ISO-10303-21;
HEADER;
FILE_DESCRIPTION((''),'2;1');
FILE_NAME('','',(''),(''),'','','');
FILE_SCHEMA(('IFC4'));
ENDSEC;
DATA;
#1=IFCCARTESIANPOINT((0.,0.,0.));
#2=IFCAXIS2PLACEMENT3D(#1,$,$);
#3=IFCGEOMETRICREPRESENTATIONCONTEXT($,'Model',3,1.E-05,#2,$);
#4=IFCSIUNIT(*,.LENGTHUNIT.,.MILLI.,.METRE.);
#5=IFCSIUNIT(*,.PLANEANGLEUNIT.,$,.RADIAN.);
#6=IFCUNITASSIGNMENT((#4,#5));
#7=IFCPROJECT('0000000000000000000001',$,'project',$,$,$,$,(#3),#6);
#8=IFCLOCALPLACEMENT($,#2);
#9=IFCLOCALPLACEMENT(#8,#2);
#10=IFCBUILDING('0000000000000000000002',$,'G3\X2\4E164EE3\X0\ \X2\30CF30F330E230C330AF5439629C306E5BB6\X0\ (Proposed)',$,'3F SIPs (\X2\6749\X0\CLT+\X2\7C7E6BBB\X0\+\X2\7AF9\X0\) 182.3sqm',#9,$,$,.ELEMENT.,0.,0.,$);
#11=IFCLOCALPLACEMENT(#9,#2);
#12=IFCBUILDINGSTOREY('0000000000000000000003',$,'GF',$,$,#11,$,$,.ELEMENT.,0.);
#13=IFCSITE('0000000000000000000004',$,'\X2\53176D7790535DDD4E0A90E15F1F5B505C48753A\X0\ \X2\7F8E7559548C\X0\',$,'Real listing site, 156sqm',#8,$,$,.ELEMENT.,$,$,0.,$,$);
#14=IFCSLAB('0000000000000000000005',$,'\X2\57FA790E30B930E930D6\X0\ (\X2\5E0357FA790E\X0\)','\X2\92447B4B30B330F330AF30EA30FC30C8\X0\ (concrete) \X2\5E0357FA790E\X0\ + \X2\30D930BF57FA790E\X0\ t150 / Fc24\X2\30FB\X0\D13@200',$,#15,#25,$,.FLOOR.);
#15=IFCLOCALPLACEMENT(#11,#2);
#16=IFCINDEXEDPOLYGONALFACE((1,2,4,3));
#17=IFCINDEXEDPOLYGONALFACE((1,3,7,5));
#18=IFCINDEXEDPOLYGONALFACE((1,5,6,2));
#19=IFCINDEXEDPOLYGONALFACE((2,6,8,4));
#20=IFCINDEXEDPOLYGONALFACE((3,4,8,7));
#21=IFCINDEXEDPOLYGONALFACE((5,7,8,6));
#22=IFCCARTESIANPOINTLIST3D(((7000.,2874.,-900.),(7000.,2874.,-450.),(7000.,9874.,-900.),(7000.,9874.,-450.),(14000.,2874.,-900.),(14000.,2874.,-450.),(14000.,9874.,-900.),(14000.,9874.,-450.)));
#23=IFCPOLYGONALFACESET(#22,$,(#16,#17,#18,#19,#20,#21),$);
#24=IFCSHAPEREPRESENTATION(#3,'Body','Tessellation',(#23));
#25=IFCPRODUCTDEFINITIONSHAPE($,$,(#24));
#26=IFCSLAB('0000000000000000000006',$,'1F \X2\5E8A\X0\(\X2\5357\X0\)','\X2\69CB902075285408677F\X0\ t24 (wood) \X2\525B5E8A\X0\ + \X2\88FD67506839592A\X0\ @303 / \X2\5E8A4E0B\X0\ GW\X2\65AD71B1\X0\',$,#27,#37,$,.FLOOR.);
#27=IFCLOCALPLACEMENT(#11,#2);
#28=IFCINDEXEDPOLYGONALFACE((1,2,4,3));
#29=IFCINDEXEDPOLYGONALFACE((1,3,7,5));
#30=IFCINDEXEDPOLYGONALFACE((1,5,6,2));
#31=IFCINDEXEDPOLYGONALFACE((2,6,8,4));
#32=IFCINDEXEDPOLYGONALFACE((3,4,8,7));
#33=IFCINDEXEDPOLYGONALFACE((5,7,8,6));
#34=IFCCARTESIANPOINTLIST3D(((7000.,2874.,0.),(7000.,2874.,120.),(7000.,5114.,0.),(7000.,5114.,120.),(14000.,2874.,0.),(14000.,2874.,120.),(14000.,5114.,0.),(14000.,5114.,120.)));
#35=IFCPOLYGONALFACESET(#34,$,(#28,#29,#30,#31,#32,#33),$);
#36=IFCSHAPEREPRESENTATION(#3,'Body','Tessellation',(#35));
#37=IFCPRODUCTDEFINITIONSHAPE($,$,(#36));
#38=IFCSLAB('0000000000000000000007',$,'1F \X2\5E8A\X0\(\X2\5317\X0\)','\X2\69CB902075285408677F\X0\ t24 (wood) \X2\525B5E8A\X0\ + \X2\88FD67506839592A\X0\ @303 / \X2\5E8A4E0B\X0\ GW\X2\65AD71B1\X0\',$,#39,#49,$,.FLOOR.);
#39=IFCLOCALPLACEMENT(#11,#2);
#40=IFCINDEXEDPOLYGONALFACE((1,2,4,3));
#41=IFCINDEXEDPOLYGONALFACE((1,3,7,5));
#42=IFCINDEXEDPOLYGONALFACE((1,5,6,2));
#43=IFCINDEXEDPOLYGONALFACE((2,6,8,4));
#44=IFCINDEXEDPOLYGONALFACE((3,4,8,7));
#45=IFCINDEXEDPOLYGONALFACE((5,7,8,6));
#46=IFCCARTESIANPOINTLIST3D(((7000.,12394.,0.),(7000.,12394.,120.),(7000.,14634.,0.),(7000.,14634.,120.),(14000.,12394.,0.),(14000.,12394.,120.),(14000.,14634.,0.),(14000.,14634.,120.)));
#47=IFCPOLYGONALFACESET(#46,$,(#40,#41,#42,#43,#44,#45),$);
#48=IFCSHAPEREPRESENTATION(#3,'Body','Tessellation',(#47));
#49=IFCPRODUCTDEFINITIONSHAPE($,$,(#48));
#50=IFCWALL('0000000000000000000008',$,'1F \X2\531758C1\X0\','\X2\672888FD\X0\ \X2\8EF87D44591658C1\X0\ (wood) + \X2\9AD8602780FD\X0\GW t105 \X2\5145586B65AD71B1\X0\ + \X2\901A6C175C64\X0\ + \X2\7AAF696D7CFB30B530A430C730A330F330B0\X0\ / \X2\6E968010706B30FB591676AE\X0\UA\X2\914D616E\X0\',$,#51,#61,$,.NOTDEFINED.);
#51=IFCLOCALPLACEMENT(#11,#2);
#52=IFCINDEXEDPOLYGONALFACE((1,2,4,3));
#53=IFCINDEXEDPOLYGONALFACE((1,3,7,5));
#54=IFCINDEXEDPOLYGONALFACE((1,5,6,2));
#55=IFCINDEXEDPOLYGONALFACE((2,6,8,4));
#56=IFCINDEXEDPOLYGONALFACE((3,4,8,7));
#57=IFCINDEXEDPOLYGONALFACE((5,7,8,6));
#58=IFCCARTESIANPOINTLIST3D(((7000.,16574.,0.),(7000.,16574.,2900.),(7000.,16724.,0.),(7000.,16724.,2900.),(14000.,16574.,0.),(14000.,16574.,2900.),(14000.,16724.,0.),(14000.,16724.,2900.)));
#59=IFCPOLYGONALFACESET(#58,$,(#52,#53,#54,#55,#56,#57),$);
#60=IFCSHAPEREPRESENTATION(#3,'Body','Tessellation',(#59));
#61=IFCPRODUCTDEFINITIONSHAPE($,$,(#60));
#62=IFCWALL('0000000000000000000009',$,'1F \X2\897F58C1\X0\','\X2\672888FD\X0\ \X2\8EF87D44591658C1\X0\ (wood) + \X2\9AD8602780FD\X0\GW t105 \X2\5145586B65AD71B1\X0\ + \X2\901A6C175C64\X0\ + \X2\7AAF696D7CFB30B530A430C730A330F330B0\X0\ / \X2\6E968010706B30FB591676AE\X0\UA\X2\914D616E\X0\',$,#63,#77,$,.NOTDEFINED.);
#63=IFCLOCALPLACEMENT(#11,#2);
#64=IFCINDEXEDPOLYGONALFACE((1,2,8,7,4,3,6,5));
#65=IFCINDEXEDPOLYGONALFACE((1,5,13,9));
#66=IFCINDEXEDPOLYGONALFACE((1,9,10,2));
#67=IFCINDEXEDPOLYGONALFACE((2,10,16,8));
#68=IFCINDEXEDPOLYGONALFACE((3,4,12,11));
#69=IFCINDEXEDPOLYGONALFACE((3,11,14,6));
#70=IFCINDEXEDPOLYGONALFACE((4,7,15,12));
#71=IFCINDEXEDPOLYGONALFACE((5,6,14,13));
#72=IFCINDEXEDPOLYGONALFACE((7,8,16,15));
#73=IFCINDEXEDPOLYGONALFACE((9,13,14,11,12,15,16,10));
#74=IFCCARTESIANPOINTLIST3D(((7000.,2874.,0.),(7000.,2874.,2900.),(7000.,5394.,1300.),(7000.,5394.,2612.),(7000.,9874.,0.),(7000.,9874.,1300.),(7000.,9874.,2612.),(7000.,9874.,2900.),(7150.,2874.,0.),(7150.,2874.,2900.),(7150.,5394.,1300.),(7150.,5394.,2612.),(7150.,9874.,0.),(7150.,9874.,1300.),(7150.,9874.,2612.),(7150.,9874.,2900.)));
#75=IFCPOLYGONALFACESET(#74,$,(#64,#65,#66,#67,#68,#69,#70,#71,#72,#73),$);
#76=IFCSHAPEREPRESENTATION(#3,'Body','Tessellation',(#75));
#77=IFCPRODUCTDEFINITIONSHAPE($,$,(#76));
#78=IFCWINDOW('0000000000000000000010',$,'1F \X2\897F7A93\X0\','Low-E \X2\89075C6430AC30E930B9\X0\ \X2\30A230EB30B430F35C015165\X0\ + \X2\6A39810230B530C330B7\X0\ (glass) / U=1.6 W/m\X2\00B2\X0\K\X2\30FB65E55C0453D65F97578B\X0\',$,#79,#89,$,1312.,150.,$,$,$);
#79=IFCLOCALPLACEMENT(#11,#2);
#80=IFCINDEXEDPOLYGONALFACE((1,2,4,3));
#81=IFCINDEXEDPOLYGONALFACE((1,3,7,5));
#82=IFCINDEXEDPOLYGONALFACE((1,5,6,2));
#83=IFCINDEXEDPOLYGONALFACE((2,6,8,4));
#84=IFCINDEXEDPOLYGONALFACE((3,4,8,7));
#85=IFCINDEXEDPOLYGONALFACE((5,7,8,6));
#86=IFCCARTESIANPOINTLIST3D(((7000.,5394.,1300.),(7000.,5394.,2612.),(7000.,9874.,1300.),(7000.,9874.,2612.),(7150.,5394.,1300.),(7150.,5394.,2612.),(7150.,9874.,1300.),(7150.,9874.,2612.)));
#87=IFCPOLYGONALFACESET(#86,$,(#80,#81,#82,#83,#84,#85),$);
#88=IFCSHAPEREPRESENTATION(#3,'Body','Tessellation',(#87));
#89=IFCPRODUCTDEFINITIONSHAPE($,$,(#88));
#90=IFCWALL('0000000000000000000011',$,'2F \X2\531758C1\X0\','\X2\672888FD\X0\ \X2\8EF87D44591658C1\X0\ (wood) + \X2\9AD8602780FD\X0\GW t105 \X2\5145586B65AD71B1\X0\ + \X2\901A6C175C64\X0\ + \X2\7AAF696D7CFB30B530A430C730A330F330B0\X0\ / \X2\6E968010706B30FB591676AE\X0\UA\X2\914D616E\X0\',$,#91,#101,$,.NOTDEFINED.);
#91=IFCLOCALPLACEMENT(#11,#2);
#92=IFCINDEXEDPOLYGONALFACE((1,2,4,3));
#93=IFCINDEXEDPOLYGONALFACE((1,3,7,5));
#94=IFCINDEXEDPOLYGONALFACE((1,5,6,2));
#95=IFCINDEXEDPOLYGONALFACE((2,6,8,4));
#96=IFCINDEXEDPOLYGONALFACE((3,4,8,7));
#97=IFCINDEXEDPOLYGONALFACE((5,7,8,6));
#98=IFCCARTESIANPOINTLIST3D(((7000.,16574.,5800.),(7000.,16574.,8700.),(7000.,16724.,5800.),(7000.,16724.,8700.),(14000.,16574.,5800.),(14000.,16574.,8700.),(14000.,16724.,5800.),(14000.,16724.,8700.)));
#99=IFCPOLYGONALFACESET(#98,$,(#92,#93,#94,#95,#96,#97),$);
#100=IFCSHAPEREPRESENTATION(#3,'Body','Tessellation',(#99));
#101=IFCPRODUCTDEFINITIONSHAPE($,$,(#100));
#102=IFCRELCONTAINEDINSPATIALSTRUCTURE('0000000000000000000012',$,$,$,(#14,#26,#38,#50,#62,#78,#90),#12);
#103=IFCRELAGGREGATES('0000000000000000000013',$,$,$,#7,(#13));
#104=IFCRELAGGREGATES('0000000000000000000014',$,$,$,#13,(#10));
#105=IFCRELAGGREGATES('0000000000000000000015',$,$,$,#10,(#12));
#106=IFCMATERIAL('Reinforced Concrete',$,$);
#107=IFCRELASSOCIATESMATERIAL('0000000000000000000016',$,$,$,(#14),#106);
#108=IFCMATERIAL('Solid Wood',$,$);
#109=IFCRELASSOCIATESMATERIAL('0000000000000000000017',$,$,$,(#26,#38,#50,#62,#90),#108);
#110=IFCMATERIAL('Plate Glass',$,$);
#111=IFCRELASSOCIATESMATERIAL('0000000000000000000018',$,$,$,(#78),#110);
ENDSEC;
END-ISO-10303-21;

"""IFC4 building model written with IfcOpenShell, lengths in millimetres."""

from ifc_helpers import new_model, si_unit, frame, frame_2d, origin, place, context, project, spatial, rectangle, extrude, material, element, fill, save


model = new_model("IFC4")

# Units and contexts
model_context = context("Model", 3, precision=1e-05, world=origin())
ifc_project = project(units=[si_unit("LENGTHUNIT", "METRE", prefix="MILLI"), si_unit("PLANEANGLEUNIT", "RADIAN")], contexts=[model_context])

# Site, building, storey
site_placement = place(None, origin())
site = spatial("IfcSite", under=ifc_project, at=site_placement, Name="北海道川上郡弟子屈町 美留和", ObjectType="Real listing site, 156sqm", CompositionType="ELEMENT", RefElevation=0.0)
building_placement = place(site_placement, origin())
building = spatial("IfcBuilding", under=site, at=building_placement, Name="G3世代 ハンモック吹抜の家 (Proposed)", ObjectType="3F SIPs (杉CLT+籾殻+竹) 182.3sqm", CompositionType="ELEMENT", ElevationOfRefHeight=0.0, ElevationOfTerrain=0.0)
storey_placement = place(building_placement, origin())
storey = spatial("IfcBuildingStorey", under=building, at=storey_placement, Name="GF", CompositionType="ELEMENT", Elevation=0.0)

# Slabs
ifc_material_1 = material(Name="Reinforced Concrete")
slab_1_placement = place(storey_placement, frame((3500.0, 1437.0, -450.0)))
element("IfcSlab", 1, at=slab_1_placement, inside=storey, material=ifc_material_1, Name="基礎スラブ (布基礎)", Description="鉄筋コンクリート (concrete) 布基礎 + ベタ基礎 t150 / Fc24・D13@200", PredefinedType="FLOOR", context=model_context, shape_type="SweptSolid", body=[
    extrude(rectangle(XDim=7000.0, YDim=7000.0, at=frame_2d((3500.0, 3500.0))), frame((3500.0, 1437.0, -450.0)), (0.0, 0.0, 1.0), 450.0),
])
ifc_material_2 = material(Name="Solid Wood")
slab_2_placement = place(storey_placement, frame((3500.0, 1437.0, 0.0)))
element("IfcSlab", 2, at=slab_2_placement, inside=storey, material=ifc_material_2, Name="1F 床(南)", Description="構造用合板 t24 (wood) 剛床 + 製材根太 @303 / 床下 GW断熱", PredefinedType="FLOOR", context=model_context, shape_type="SweptSolid", body=[
    extrude(rectangle(XDim=7000.0, YDim=2240.0, at=frame_2d((3500.0, 1120.0))), frame((3500.0, 1437.0, 0.0)), (0.0, 0.0, 1.0), 120.0),
])
slab_3_placement = place(storey_placement, frame((3500.0, 6197.0, 0.0)))
element("IfcSlab", 3, at=slab_3_placement, inside=storey, material=ifc_material_2, Name="1F 床(北)", Description="構造用合板 t24 (wood) 剛床 + 製材根太 @303 / 床下 GW断熱", PredefinedType="FLOOR", context=model_context, shape_type="SweptSolid", body=[
    extrude(rectangle(XDim=7000.0, YDim=2240.0, at=frame_2d((3500.0, 1120.0))), frame((3500.0, 6197.0, 0.0)), (0.0, 0.0, 1.0), 120.0),
])

# Shared definitions
ifc_material_3 = material(Name="Plate Glass")

# Wall
wall_1_placement = place(storey_placement, frame((3500.0, 8287.0, 0.0)))
element("IfcWall", 4, at=wall_1_placement, inside=storey, material=ifc_material_2, Name="1F 北壁", Description="木製 軸組外壁 (wood) + 高性能GW t105 充填断熱 + 通気層 + 窯業系サイディング / 準耐火・外皮UA配慮", PredefinedType="NOTDEFINED", context=model_context, shape_type="SweptSolid", body=[
    extrude(rectangle(XDim=7000.0, YDim=150.0, at=frame_2d((3500.0, 75.0))), frame((3500.0, 8287.0, 0.0)), (0.0, 0.0, 1.0), 2900.0),
])

# Wall, opening, window
wall_2_placement = place(storey_placement, frame((3500.0, 1437.0, 0.0)))
wall_2 = element("IfcWall", 5, at=wall_2_placement, inside=storey, material=ifc_material_2, Name="1F 西壁", Description="木製 軸組外壁 (wood) + 高性能GW t105 充填断熱 + 通気層 + 窯業系サイディング / 準耐火・外皮UA配慮", PredefinedType="NOTDEFINED", context=model_context, shape_type="SweptSolid", body=[
    extrude(rectangle(XDim=150.0, YDim=7000.0, at=frame_2d((75.0, 3500.0))), frame((3500.0, 1437.0, 0.0)), (0.0, 0.0, 1.0), 2900.0),
])
opening_1_placement = place(storey_placement, frame((3500.0, 2697.0, 650.0)))
opening_1 = element("IfcOpeningElement", 6, at=opening_1_placement, cuts=wall_2, PredefinedType="NOTDEFINED", context=model_context, shape_type="SweptSolid", body=[
    extrude(rectangle(XDim=150.0, YDim=4480.0, at=frame_2d((75.0, 2240.0))), frame((3500.0, 2697.0, 650.0)), (0.0, 0.0, 1.0), 1312.0),
])
window_1_placement = place(storey_placement, frame((3500.0, 2697.0, 650.0)))
window_1 = element("IfcWindow", 7, at=window_1_placement, inside=storey, material=ifc_material_3, Name="1F 西窓", Description="Low-E 複層ガラス アルゴン封入 + 樹脂サッシ (glass) / U=1.6 W/m²K・日射取得型", OverallHeight=1312.0, OverallWidth=150.0, context=model_context, shape_type="SweptSolid", body=[
    extrude(rectangle(XDim=150.0, YDim=4480.0, at=frame_2d((75.0, 2240.0))), frame((3500.0, 2697.0, 650.0)), (0.0, 0.0, 1.0), 1312.0),
])
fill(opening_1, window_1)

# Wall
wall_3_placement = place(storey_placement, frame((3500.0, 8287.0, 2900.0)))
element("IfcWall", 8, at=wall_3_placement, inside=storey, material=ifc_material_2, Name="2F 北壁", Description="木製 軸組外壁 (wood) + 高性能GW t105 充填断熱 + 通気層 + 窯業系サイディング / 準耐火・外皮UA配慮", PredefinedType="NOTDEFINED", context=model_context, shape_type="SweptSolid", body=[
    extrude(rectangle(XDim=7000.0, YDim=150.0, at=frame_2d((3500.0, 75.0))), frame((3500.0, 8287.0, 2900.0)), (0.0, 0.0, 1.0), 2900.0),
])

save(model, "model.ifc")
